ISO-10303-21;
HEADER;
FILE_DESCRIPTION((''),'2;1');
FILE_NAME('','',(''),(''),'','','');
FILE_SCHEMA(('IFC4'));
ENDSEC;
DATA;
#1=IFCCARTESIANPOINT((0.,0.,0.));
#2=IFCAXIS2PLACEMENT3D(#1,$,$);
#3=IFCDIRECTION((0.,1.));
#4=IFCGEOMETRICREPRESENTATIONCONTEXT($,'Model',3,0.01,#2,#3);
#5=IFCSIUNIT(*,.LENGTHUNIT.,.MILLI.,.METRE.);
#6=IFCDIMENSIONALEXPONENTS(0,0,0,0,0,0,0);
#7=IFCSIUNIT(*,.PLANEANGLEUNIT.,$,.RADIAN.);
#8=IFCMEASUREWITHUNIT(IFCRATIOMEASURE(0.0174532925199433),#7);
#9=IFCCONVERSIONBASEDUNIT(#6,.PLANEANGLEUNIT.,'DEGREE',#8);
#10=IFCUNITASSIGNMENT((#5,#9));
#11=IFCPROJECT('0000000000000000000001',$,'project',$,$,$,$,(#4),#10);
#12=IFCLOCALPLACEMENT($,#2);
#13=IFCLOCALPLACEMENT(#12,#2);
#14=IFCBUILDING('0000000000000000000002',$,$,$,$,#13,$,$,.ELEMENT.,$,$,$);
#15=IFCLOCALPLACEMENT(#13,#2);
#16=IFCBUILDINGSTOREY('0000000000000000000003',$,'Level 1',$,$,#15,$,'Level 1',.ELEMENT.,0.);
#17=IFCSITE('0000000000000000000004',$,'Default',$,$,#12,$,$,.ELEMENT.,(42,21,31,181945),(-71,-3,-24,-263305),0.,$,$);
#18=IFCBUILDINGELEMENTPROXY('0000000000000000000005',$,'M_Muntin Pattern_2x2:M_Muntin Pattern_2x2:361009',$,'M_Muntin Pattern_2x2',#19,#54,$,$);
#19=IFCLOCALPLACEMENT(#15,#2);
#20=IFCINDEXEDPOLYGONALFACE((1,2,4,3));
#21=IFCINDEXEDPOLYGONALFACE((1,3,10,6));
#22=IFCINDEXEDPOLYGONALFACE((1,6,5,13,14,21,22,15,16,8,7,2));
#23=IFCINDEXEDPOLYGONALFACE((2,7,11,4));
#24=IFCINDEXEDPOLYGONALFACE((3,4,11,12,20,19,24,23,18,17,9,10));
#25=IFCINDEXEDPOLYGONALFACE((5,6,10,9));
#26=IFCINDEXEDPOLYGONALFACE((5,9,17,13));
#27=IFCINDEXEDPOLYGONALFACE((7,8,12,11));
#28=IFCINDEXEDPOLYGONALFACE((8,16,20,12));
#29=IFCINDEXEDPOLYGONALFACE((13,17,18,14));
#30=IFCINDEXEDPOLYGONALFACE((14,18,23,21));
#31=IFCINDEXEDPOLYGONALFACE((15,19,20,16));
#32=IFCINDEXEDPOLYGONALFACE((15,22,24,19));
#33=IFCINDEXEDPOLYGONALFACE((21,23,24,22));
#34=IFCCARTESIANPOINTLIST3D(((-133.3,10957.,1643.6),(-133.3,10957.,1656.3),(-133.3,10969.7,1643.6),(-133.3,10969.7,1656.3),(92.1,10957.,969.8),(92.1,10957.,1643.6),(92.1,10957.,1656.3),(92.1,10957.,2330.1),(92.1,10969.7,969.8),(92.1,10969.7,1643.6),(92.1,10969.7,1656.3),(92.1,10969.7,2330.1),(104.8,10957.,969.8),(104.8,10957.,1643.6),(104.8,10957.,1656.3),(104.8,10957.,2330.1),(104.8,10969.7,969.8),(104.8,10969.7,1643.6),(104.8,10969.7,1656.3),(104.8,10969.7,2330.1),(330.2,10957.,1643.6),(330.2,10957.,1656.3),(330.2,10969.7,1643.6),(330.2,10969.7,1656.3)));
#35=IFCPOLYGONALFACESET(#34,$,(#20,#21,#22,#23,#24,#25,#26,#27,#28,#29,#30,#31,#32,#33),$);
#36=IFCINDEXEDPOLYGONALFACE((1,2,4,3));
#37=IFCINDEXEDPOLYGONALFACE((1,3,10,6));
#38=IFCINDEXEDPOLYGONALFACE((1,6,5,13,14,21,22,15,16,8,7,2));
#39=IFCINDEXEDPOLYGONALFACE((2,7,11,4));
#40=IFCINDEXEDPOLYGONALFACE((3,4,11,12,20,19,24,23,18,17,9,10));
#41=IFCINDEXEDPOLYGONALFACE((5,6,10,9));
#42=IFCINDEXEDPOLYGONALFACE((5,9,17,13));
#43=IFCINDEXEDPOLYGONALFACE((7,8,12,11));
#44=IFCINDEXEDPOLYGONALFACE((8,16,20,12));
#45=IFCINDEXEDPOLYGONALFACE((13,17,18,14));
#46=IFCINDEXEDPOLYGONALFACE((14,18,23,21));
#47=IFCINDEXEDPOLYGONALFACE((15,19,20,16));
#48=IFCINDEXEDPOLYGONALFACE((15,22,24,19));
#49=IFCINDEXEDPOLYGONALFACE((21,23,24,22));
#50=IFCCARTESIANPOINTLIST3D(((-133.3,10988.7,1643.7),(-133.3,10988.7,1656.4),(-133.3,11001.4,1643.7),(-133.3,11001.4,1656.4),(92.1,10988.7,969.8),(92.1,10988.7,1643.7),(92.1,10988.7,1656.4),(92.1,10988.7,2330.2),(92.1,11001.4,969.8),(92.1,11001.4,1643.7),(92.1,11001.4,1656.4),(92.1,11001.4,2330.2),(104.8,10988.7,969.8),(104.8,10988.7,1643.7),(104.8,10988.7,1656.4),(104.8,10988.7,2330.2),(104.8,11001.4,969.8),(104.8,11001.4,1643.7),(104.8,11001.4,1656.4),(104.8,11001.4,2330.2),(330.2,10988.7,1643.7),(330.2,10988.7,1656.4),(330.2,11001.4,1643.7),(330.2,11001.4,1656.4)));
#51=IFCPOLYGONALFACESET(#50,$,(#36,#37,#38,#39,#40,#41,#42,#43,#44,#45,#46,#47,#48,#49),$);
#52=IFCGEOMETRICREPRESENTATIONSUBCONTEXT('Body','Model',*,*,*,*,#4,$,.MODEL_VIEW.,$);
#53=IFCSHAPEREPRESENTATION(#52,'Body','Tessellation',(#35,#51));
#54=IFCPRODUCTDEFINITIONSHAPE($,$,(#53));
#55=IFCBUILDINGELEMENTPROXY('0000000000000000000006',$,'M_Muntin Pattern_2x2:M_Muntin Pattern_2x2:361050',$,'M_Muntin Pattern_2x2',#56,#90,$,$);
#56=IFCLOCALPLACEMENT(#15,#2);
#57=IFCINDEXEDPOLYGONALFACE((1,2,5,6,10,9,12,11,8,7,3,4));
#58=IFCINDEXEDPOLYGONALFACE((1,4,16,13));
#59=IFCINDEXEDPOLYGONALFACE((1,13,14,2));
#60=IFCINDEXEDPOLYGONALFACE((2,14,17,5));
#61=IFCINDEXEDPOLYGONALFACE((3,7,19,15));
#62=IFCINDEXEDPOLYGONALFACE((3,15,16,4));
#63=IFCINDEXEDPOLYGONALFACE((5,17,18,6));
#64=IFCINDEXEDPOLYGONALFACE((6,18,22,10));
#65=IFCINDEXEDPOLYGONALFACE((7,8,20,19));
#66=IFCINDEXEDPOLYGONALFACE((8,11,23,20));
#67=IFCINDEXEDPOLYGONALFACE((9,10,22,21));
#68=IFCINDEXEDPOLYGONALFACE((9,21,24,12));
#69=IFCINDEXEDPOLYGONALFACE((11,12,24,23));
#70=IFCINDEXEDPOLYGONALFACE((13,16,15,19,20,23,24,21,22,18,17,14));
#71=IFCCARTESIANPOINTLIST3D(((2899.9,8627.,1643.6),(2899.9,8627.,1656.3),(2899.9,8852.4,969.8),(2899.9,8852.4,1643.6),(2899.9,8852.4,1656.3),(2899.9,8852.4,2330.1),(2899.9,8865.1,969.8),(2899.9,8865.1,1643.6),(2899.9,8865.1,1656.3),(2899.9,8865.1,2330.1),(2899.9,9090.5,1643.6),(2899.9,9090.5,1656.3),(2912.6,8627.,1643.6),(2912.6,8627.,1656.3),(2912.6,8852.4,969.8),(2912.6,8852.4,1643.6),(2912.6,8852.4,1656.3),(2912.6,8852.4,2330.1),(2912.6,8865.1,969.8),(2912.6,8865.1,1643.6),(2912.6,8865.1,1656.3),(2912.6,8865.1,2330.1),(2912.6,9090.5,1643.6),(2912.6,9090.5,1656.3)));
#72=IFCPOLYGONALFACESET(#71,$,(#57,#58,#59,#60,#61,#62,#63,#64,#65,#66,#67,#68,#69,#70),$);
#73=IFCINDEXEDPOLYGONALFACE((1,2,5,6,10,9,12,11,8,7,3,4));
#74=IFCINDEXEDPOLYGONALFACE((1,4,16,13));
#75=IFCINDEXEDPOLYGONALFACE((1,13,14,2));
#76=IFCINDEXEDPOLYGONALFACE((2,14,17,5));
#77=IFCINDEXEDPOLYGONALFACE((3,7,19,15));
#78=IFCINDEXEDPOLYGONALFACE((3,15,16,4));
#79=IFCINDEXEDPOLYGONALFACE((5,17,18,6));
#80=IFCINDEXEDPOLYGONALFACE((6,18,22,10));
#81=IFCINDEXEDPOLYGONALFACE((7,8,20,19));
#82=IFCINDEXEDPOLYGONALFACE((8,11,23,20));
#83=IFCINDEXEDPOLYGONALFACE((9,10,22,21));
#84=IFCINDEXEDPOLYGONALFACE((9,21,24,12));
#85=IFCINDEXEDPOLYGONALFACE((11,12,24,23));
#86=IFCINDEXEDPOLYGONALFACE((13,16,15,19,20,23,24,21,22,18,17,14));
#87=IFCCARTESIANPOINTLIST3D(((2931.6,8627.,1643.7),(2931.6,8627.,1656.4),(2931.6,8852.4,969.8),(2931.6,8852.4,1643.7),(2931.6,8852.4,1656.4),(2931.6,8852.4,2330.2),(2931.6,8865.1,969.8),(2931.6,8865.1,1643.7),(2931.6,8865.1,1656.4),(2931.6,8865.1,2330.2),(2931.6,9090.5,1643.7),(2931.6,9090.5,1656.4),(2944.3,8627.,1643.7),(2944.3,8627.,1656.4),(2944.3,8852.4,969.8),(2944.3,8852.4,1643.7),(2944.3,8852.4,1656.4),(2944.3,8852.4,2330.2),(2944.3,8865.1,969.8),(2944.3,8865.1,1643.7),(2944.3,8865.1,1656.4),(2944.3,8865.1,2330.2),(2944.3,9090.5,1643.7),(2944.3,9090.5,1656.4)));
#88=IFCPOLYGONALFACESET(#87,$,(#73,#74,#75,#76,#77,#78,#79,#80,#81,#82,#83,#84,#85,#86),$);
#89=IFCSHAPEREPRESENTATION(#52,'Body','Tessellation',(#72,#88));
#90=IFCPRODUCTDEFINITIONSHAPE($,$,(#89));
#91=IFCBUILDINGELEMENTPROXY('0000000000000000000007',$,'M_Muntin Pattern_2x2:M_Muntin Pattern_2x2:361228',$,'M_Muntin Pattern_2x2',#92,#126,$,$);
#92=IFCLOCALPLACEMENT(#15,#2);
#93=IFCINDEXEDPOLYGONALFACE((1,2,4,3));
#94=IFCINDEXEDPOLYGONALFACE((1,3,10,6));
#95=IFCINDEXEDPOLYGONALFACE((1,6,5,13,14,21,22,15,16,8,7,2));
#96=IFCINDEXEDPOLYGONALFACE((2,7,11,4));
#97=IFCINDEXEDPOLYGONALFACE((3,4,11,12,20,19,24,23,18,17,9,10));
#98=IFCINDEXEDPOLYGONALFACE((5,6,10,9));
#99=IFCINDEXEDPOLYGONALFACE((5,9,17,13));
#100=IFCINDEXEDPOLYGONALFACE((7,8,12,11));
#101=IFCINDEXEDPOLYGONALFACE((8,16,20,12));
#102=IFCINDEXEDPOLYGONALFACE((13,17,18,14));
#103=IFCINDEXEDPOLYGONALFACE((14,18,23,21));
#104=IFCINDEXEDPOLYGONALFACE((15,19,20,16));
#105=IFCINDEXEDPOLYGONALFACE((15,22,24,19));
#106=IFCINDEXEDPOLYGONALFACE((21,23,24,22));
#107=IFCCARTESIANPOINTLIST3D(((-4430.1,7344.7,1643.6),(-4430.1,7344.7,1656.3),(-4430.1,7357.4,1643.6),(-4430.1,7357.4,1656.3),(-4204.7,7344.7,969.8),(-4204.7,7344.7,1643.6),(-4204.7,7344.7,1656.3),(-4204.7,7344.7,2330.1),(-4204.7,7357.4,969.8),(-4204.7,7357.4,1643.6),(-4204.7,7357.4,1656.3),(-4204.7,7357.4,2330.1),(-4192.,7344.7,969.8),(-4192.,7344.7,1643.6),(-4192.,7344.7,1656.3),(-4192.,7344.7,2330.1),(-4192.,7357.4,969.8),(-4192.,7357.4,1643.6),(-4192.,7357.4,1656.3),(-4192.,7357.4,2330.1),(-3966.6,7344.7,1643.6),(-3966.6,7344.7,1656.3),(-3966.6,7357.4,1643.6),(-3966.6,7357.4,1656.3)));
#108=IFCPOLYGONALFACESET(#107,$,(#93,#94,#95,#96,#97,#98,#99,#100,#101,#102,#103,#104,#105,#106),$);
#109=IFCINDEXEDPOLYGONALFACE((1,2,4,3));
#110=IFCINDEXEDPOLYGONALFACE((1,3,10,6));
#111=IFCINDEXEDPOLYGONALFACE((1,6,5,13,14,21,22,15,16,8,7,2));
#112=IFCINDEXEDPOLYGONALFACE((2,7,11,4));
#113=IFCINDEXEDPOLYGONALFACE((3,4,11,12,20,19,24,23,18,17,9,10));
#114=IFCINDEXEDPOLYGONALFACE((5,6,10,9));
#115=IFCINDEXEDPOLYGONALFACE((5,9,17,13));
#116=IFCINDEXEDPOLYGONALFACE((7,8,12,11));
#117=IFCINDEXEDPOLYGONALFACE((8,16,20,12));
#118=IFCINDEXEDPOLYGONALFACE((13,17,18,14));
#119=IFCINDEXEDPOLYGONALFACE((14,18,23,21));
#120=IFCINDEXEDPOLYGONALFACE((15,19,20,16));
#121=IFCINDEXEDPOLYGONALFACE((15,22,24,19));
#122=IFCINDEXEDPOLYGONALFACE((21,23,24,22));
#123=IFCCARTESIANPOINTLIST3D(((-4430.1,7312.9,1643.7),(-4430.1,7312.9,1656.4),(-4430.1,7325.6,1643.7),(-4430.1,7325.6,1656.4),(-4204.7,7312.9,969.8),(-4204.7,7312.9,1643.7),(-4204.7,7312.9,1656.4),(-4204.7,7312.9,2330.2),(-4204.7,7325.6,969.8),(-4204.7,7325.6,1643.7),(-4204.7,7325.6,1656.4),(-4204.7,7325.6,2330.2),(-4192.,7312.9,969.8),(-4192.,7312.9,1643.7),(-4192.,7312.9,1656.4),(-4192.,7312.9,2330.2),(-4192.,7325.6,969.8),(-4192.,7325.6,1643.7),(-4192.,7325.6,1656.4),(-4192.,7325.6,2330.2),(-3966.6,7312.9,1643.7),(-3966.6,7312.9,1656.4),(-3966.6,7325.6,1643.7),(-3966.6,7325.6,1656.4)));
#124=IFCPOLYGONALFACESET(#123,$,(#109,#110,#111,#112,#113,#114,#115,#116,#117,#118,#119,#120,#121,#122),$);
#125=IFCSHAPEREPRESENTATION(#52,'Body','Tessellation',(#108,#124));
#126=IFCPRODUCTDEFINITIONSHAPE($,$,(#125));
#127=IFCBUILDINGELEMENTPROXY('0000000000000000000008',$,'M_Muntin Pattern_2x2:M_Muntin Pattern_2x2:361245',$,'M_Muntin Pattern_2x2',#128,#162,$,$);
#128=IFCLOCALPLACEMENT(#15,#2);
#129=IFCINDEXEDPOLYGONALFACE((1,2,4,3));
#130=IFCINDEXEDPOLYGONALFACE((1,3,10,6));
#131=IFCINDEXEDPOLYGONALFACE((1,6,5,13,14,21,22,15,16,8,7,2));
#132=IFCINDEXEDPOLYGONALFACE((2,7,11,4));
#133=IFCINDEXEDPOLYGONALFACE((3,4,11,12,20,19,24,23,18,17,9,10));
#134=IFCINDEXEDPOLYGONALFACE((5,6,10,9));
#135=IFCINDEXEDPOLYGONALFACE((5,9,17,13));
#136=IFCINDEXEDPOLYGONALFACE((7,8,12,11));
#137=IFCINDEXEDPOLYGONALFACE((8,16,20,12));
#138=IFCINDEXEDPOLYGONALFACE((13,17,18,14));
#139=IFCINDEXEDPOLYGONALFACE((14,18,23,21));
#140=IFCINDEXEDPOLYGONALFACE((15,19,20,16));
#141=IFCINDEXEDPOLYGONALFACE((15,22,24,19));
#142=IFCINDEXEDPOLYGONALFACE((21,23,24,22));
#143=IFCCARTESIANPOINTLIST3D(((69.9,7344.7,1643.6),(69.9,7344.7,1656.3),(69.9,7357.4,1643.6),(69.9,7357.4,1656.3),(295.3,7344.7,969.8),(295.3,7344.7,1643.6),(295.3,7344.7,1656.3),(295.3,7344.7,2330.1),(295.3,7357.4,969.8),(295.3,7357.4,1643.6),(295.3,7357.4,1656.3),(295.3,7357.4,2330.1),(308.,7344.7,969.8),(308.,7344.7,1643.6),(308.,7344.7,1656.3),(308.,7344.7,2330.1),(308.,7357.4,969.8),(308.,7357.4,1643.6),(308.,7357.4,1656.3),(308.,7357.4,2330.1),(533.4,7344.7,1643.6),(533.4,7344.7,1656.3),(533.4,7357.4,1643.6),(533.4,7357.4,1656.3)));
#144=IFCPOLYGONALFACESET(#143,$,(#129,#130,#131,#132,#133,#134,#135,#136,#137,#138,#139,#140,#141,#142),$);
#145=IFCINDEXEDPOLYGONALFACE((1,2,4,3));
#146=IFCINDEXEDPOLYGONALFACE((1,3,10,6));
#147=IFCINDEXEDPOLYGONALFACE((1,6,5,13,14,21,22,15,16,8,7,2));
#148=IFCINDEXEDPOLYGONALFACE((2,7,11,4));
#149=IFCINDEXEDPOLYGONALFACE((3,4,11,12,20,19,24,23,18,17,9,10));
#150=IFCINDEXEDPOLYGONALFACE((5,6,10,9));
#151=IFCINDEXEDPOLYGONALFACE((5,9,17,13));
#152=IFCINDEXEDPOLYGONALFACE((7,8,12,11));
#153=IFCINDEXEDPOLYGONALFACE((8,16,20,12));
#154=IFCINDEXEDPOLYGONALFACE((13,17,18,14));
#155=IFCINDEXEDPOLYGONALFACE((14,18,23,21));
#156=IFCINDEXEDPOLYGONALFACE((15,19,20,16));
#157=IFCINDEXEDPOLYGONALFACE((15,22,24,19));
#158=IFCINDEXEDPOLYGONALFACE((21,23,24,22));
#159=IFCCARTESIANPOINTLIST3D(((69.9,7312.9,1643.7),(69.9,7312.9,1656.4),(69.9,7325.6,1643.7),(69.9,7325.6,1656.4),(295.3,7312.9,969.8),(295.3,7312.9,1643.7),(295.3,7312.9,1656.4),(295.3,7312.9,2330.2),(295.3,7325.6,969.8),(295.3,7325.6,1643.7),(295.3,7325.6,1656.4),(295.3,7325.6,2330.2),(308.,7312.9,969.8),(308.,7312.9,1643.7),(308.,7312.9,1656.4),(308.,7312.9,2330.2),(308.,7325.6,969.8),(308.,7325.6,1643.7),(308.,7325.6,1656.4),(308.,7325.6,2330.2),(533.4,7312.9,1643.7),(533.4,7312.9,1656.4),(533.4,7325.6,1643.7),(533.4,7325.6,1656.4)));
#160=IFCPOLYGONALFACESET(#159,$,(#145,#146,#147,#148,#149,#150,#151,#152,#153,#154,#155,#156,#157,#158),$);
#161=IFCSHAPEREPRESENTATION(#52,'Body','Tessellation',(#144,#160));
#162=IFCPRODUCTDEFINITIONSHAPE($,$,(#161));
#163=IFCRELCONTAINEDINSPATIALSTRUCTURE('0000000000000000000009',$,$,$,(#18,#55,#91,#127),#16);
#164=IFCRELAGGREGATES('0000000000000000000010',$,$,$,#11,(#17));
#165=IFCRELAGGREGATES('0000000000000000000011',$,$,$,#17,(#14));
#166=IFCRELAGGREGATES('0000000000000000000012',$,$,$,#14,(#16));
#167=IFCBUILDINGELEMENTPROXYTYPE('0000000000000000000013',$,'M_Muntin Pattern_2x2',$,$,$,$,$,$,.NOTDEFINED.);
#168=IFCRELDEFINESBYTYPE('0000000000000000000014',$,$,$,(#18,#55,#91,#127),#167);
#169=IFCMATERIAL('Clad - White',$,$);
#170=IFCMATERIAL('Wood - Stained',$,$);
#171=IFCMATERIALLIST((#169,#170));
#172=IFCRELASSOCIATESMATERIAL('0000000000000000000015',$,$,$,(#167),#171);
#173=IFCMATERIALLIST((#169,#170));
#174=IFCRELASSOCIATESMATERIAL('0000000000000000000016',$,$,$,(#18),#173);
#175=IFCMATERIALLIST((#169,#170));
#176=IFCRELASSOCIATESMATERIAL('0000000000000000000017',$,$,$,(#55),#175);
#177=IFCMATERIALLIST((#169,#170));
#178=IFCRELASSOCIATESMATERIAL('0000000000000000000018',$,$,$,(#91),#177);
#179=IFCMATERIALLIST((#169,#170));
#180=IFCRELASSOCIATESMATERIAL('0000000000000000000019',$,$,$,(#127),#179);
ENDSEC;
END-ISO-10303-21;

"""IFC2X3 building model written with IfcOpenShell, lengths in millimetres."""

from ifc_helpers import new_model, entity, si_unit, converted_unit, direction, frame, origin, place, context, subcontext, project, spatial, polyline, outline, extrude, source, transform, mapped, material, material_list, type_object, type_shapes, element, save


model = new_model("IFC2X3")

# Units and contexts
model_context = context("Model", 3, precision=0.01, world=origin(), true_north=direction((0.0, 1.0)))
body_context = subcontext(model_context, "Body", "Model", "MODEL_VIEW")
ifc_project = project(units=[si_unit("LENGTHUNIT", "METRE", prefix="MILLI"), converted_unit("PLANEANGLEUNIT", "DEGREE", entity("IfcRatioMeasure", 0.0174532925199433), si_unit("PLANEANGLEUNIT", "RADIAN"), dimensions=[0, 0, 0, 0, 0, 0, 0])], contexts=[model_context])

# Site, building, storey
site_placement = place(None, origin())
site = spatial("IfcSite", under=ifc_project, at=site_placement, Name="Default", CompositionType="ELEMENT", RefLatitude=(42, 21, 31, 181945), RefLongitude=(-71, -3, -24, -263305), RefElevation=0.0)
building_placement = place(site_placement, origin())
building = spatial("IfcBuilding", under=site, at=building_placement, CompositionType="ELEMENT")
storey_placement = place(building_placement, origin())
storey = spatial("IfcBuildingStorey", under=building, at=storey_placement, Name="Level 1", LongName="Level 1", CompositionType="ELEMENT", Elevation=0.0)

# Building element proxies
ifc_material_1 = material(Name="Clad - White")
ifc_material_2 = material(Name="Wood - Stained")
ifc_material_list_1 = material_list([ifc_material_1, ifc_material_2])
building_element_proxy_type_1 = type_object("IfcBuildingElementProxyType", Name="M_Muntin Pattern_2x2", PredefinedType="NOTDEFINED", material=ifc_material_list_1)
shared_shape_1 = source(origin(), body_context, "Body", "SweptSolid", [
    extrude(outline(polyline([(6.4, -6.4), (680.1, -6.4), (680.1, 6.3), (6.4, 6.3), (6.4, 231.7), (-6.3, 231.7), (-6.3, 6.3), (-680.2, 6.3), (-680.2, -6.4), (-6.3, -6.4), (-6.3, -231.7), (6.4, -231.7), (6.4, -6.4)])), frame((0.0, 9.5, 680.1), z_axis=(0.0, 1.0, 0.0), x_axis=(0.0, 0.0, 1.0)), (0.0, 0.0, 1.0), 12.7),
    extrude(outline(polyline([(6.4, -6.4), (680.2, -6.4), (680.2, 6.3), (6.4, 6.3), (6.4, 231.7), (-6.3, 231.7), (-6.3, 6.3), (-680.2, 6.3), (-680.2, -6.4), (-6.3, -6.4), (-6.3, -231.7), (6.4, -231.7), (6.4, -6.4)])), frame((0.0, -22.2, 680.2), z_axis=(0.0, 1.0, 0.0), x_axis=(0.0, 0.0, 1.0)), (0.0, 0.0, 1.0), 12.7),
])
type_shapes(building_element_proxy_type_1, [shared_shape_1])
ifc_material_list_2 = material_list([ifc_material_1, ifc_material_2])
proxy_1_placement = place(storey_placement, frame((98.5, 10979.2, 969.8), z_axis=(0.0, 0.0, 1.0), x_axis=(-1.0, 0.0, 0.0)))
element("IfcBuildingElementProxy", 1, at=proxy_1_placement, inside=storey, type_object=building_element_proxy_type_1, material=ifc_material_list_2, Name="M_Muntin Pattern_2x2:M_Muntin Pattern_2x2:361009", ObjectType="M_Muntin Pattern_2x2", context=body_context, shape_type="MappedRepresentation", body=[
    mapped(shared_shape_1, transform((0.0, 0.0, 0.0), scale=1.0)),
])
ifc_material_list_3 = material_list([ifc_material_1, ifc_material_2])
proxy_2_placement = place(storey_placement, frame((2922.1, 8858.7, 969.8), z_axis=(0.0, 0.0, 1.0), x_axis=(0.0, 1.0, 0.0)))
element("IfcBuildingElementProxy", 2, at=proxy_2_placement, inside=storey, type_object=building_element_proxy_type_1, material=ifc_material_list_3, Name="M_Muntin Pattern_2x2:M_Muntin Pattern_2x2:361050", ObjectType="M_Muntin Pattern_2x2", context=body_context, shape_type="MappedRepresentation", body=[
    mapped(shared_shape_1, transform((0.0, 0.0, 0.0), scale=1.0)),
])
ifc_material_list_4 = material_list([ifc_material_1, ifc_material_2])
proxy_3_placement = place(storey_placement, frame((-4198.4, 7335.1, 969.8)))
element("IfcBuildingElementProxy", 3, at=proxy_3_placement, inside=storey, type_object=building_element_proxy_type_1, material=ifc_material_list_4, Name="M_Muntin Pattern_2x2:M_Muntin Pattern_2x2:361228", ObjectType="M_Muntin Pattern_2x2", context=body_context, shape_type="MappedRepresentation", body=[
    mapped(shared_shape_1, transform((0.0, 0.0, 0.0), scale=1.0)),
])
ifc_material_list_5 = material_list([ifc_material_1, ifc_material_2])
proxy_4_placement = place(storey_placement, frame((301.6, 7335.1, 969.8)))
element("IfcBuildingElementProxy", 4, at=proxy_4_placement, inside=storey, type_object=building_element_proxy_type_1, material=ifc_material_list_5, Name="M_Muntin Pattern_2x2:M_Muntin Pattern_2x2:361245", ObjectType="M_Muntin Pattern_2x2", context=body_context, shape_type="MappedRepresentation", body=[
    mapped(shared_shape_1, transform((0.0, 0.0, 0.0), scale=1.0)),
])

save(model, "model.ifc")
